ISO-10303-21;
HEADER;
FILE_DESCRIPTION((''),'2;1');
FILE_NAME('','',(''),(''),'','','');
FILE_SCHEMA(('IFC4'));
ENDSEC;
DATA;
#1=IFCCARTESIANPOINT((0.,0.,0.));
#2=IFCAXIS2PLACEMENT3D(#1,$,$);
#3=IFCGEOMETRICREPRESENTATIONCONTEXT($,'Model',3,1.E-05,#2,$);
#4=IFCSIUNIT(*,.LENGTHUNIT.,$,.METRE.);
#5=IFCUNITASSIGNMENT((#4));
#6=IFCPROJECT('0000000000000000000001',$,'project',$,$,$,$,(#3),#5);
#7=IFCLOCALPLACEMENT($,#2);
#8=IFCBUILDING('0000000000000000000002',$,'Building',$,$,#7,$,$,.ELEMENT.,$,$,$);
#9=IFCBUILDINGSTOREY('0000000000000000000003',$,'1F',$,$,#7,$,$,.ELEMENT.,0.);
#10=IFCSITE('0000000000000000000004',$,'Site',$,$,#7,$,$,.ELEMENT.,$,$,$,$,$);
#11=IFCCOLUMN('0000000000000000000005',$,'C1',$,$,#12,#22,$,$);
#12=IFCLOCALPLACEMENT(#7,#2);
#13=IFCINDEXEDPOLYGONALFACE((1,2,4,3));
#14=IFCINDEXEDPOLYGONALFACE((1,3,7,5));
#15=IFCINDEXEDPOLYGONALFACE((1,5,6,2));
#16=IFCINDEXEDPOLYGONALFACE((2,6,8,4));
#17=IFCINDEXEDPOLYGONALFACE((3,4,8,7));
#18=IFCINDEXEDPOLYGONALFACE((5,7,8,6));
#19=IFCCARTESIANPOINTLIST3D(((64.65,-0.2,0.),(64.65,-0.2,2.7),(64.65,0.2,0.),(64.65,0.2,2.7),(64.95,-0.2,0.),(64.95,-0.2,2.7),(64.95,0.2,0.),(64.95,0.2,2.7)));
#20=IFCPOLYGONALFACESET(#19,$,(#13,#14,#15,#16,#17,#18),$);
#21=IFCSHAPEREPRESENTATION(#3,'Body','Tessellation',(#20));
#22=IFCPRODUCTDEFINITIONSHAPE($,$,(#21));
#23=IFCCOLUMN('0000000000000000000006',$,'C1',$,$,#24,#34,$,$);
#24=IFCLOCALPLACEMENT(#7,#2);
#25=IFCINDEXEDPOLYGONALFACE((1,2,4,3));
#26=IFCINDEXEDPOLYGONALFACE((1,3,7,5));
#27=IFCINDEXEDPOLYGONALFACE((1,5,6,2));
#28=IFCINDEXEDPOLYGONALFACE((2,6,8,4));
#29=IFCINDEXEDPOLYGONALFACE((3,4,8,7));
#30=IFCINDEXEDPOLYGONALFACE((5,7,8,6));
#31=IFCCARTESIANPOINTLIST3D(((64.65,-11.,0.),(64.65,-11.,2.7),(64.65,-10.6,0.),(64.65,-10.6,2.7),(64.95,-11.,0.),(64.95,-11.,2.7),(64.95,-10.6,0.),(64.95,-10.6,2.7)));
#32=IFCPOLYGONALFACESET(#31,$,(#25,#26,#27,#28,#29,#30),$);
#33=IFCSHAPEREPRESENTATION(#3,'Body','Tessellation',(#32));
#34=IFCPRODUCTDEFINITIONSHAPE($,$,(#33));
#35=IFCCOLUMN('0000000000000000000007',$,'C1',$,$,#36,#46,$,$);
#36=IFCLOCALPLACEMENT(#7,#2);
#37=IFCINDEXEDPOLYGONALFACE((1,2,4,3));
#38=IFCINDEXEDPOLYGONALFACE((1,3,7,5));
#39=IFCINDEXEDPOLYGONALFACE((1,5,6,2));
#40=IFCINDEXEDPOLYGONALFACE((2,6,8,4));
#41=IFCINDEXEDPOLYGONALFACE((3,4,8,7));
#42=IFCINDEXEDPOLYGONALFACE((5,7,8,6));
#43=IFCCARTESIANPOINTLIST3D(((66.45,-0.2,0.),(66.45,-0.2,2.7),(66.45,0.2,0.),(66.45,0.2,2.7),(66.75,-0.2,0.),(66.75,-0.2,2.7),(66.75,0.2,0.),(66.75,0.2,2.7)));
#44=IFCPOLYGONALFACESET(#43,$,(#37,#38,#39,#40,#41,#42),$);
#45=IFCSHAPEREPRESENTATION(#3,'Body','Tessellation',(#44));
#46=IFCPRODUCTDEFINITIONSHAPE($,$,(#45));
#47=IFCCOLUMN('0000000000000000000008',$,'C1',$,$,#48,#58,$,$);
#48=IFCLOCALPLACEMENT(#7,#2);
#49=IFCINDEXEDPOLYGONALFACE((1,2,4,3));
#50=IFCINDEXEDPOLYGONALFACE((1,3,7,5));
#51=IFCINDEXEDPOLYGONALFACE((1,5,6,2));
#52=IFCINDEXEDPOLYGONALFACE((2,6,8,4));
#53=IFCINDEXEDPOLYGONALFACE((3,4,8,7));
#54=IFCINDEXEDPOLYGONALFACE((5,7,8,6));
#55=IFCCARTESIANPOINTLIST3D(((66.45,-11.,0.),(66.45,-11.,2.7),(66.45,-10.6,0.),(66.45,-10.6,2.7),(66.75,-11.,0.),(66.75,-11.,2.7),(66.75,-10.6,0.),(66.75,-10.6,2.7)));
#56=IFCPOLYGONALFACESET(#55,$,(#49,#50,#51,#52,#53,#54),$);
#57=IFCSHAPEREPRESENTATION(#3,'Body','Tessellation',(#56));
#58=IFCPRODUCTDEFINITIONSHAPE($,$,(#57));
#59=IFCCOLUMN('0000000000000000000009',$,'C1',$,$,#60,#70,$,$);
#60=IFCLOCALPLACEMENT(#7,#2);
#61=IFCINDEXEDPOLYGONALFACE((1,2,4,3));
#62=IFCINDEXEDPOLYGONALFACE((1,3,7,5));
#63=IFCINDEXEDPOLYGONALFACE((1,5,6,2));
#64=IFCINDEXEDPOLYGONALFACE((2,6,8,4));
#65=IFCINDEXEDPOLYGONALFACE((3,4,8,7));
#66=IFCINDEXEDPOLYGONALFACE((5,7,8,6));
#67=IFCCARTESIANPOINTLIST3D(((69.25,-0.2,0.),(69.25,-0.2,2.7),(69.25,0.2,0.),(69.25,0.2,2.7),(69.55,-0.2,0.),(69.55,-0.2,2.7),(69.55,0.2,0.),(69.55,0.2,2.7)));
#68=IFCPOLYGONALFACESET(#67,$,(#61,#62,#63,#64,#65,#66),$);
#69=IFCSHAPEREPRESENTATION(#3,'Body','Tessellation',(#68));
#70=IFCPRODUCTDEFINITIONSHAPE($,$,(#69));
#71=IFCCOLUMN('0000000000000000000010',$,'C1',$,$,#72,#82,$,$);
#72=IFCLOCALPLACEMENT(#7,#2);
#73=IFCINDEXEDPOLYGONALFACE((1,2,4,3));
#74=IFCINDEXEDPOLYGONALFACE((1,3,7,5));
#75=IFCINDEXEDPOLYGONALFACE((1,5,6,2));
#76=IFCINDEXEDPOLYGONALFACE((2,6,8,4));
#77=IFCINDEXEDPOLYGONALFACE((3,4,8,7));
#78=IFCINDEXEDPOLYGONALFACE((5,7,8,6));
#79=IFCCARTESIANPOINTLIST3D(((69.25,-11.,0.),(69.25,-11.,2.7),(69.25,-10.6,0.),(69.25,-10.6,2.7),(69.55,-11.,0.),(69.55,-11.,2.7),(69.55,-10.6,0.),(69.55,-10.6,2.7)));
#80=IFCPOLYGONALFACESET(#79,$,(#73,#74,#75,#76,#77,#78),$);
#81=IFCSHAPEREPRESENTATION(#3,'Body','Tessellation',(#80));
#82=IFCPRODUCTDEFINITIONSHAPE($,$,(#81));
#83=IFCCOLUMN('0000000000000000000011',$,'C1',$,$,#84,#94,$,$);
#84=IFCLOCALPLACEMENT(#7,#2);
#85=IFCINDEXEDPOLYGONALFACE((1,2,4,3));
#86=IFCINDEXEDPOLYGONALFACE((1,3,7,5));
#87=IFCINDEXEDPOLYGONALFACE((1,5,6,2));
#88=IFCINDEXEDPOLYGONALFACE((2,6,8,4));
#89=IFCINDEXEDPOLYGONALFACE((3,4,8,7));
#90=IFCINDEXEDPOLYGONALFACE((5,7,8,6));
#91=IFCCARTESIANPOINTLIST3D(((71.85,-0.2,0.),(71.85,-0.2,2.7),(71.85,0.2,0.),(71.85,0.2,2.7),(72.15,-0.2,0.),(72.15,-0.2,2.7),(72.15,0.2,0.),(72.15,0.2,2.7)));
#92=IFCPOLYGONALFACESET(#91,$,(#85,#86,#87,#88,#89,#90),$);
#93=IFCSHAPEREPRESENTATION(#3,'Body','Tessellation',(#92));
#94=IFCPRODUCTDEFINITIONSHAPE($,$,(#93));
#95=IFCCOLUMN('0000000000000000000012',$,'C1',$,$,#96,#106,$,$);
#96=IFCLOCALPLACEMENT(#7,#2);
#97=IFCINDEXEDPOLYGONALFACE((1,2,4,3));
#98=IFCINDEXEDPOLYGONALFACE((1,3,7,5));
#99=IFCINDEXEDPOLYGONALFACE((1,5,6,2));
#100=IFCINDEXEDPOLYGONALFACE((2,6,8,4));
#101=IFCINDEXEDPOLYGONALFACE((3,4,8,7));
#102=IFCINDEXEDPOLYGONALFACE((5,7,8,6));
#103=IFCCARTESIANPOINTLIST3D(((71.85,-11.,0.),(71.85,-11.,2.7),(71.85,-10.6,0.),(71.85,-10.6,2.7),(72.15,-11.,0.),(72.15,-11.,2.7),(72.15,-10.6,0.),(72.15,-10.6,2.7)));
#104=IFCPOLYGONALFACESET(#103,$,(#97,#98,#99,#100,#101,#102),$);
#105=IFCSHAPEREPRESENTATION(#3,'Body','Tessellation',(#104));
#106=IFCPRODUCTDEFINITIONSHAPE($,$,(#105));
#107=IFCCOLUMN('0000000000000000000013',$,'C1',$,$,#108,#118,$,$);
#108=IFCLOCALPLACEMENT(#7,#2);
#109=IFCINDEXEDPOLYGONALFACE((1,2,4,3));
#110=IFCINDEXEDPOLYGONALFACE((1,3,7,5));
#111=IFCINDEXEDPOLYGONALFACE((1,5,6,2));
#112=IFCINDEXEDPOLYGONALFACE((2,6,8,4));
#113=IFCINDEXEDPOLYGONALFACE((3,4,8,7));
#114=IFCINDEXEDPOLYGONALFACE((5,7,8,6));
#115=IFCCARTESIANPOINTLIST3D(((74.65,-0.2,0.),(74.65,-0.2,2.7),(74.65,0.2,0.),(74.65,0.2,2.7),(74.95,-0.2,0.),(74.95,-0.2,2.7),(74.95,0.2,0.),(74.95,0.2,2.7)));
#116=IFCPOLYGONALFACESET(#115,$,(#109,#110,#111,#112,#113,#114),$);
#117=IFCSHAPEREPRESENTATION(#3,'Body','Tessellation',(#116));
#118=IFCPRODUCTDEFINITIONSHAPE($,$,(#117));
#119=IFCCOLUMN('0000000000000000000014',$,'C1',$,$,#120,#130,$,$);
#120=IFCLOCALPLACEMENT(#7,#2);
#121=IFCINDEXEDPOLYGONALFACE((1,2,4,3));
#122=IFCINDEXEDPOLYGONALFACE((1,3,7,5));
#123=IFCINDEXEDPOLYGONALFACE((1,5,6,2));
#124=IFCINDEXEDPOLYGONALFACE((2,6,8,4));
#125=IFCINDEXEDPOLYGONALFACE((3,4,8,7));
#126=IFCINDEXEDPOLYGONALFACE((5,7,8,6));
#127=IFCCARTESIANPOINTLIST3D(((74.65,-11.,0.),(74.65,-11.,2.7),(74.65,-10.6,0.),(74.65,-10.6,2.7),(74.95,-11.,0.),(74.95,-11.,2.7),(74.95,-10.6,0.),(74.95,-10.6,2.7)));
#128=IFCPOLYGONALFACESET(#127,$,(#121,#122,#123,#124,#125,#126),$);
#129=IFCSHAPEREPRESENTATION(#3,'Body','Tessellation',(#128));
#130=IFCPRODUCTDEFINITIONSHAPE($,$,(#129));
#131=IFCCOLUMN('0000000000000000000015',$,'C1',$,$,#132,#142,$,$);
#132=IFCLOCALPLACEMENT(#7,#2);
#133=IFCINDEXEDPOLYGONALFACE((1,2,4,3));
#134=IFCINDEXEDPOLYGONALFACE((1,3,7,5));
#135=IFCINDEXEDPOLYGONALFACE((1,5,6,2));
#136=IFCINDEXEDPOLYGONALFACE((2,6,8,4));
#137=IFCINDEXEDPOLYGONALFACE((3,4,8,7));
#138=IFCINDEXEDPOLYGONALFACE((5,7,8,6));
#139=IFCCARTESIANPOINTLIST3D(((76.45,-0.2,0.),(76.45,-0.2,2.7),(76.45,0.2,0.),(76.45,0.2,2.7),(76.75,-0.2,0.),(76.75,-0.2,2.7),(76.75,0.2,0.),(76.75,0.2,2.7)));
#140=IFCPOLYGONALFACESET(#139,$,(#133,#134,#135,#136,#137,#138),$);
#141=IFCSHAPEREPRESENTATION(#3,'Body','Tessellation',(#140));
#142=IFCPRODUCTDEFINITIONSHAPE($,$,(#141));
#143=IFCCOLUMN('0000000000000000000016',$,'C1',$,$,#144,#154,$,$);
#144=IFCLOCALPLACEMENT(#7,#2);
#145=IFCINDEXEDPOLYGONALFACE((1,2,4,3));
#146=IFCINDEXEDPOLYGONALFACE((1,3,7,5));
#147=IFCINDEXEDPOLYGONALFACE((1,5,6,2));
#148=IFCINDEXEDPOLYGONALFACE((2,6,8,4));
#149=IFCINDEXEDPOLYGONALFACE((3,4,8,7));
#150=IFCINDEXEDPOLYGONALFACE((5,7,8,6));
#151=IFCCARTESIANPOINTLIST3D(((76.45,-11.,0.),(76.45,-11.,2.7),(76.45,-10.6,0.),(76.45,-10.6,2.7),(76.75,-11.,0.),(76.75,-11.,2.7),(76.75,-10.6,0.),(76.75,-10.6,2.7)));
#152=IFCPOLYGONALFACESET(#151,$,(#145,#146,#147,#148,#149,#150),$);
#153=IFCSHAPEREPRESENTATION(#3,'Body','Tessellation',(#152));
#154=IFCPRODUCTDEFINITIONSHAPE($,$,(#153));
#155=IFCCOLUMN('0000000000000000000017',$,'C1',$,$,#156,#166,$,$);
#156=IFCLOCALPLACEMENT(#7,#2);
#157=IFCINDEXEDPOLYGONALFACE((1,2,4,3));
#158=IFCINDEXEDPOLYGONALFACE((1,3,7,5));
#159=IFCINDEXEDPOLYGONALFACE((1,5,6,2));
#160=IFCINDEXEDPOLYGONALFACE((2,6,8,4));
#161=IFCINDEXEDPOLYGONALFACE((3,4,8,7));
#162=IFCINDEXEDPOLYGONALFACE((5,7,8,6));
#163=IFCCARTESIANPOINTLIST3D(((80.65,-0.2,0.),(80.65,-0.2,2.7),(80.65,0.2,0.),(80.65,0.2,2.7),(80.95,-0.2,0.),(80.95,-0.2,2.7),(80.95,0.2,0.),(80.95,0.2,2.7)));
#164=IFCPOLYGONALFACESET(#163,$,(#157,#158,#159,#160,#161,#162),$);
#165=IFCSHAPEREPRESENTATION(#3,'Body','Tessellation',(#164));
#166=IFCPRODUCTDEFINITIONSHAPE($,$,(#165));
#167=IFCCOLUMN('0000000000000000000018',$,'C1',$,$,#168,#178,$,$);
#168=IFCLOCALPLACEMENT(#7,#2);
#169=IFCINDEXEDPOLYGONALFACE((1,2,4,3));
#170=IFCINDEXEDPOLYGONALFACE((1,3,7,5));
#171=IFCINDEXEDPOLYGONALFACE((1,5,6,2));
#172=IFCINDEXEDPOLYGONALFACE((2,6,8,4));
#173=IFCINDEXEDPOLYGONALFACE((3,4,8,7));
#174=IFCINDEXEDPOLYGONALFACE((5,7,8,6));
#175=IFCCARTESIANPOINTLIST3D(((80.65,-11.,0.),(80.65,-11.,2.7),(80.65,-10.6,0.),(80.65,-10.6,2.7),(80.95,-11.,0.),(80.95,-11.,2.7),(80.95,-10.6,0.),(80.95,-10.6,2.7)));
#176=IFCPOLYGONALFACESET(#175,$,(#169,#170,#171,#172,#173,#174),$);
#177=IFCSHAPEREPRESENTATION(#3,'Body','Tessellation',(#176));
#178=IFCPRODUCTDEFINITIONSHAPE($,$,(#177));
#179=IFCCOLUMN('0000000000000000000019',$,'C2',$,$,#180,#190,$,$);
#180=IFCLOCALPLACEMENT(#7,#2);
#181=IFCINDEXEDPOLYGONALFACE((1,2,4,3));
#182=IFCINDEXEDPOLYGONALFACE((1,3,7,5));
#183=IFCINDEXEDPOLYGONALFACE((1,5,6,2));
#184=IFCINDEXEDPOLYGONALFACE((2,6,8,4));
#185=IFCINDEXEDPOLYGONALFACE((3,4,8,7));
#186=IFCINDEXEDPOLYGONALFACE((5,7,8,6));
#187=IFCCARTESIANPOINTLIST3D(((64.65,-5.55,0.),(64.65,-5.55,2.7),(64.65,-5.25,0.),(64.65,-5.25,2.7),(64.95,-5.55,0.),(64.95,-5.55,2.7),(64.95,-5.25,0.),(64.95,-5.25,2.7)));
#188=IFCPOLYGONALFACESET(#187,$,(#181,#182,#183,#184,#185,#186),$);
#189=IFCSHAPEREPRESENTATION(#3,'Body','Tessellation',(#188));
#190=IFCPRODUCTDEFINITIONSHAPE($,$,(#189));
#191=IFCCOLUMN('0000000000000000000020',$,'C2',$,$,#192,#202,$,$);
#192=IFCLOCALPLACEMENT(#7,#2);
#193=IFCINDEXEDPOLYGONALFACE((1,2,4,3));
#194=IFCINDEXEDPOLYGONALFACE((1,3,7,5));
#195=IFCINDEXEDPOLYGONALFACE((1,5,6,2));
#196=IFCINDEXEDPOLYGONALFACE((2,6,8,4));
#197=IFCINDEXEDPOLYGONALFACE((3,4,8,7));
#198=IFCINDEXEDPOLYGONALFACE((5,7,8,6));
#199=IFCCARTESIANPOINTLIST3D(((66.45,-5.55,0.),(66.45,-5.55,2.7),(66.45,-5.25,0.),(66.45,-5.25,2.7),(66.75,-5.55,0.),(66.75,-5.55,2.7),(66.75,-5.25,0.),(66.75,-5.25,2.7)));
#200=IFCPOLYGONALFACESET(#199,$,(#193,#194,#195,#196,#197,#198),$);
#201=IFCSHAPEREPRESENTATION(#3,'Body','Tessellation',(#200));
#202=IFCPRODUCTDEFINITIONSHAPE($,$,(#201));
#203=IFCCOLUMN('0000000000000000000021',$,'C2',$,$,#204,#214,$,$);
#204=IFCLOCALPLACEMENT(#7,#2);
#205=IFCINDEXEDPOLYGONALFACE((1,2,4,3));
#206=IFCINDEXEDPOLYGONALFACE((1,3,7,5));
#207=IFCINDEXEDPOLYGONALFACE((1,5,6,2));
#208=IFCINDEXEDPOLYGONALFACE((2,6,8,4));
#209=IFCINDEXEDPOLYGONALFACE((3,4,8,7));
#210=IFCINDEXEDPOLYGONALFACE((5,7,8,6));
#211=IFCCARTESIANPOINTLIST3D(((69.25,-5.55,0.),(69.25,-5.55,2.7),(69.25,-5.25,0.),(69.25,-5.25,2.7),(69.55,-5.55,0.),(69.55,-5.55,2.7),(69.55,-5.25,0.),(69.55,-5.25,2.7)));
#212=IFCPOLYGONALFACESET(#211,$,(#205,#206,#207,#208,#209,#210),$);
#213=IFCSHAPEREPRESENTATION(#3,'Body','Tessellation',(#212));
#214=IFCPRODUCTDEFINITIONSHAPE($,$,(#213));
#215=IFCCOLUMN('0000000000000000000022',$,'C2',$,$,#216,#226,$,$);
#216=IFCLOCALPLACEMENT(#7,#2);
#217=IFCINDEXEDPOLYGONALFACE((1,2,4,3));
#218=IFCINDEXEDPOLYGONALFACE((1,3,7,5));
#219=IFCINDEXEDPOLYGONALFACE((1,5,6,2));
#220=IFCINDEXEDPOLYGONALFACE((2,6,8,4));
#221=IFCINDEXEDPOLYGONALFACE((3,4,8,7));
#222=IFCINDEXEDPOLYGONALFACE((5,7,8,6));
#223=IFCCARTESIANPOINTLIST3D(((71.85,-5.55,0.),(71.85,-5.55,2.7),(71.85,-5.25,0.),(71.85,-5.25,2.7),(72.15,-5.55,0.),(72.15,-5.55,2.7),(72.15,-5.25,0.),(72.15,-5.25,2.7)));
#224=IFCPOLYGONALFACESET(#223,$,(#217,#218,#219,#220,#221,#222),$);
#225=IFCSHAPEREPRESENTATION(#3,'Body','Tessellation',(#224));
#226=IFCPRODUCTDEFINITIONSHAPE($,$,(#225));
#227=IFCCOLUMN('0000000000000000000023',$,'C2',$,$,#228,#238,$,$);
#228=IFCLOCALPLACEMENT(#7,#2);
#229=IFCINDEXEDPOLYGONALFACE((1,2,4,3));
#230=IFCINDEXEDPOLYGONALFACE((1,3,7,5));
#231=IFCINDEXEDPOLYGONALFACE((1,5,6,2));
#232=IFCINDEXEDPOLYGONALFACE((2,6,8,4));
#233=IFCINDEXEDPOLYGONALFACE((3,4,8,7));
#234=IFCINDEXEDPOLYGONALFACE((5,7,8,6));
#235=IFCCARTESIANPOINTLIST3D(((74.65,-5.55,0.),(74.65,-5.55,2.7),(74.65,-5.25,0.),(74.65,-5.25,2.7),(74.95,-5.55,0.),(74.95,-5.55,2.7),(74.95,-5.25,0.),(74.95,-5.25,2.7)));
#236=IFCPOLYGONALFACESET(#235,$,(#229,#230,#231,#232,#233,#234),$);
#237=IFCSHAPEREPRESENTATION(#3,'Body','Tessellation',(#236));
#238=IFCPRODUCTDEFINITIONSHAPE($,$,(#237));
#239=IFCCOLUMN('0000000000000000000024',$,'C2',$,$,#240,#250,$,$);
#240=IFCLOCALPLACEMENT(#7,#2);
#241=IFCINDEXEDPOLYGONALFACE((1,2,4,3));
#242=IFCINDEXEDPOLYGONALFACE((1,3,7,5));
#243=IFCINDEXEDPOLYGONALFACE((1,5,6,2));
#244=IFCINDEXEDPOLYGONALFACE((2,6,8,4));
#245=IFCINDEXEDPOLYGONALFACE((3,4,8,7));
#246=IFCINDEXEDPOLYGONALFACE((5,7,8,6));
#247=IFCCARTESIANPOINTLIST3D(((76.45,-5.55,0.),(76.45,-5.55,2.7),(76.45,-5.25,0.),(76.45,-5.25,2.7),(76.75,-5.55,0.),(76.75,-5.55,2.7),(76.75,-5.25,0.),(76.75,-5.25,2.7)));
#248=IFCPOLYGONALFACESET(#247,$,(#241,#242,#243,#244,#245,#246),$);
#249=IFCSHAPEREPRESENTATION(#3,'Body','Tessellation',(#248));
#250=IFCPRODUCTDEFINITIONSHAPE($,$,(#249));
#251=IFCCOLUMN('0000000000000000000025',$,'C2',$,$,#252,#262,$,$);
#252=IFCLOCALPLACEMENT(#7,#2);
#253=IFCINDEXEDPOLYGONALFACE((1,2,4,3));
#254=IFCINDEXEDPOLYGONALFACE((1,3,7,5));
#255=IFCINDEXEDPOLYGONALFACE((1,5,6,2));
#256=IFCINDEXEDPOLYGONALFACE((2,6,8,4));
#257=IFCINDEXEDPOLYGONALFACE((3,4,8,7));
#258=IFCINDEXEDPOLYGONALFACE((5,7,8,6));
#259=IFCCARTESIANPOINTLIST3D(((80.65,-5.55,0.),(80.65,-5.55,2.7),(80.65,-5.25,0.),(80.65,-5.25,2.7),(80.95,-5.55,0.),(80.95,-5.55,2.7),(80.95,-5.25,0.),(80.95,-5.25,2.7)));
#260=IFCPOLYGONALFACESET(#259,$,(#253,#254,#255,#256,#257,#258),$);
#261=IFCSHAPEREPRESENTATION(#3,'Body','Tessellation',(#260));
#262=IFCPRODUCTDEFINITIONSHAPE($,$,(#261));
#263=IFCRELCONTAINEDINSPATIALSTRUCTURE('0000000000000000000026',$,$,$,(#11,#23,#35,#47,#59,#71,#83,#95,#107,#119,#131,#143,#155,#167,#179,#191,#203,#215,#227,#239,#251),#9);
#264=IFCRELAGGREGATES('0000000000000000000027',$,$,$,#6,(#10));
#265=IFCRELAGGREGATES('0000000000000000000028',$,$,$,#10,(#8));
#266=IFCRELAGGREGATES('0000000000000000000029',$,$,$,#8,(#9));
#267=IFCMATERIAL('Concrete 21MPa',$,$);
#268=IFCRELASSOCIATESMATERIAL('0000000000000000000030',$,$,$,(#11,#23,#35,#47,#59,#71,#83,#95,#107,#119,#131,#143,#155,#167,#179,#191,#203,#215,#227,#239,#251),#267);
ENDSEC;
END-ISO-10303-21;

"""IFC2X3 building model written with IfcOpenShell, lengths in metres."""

from ifc_helpers import new_model, si_unit, frame, origin, origin_2d, place, context, project, spatial, rectangle, extrude, material, element, save


model = new_model("IFC2X3")

# Units and contexts
model_context = context("Model", 3, precision=1e-05, world=origin())
ifc_project = project(units=[si_unit("LENGTHUNIT", "METRE")], contexts=[model_context])

# Site, building, storey
placement = place(None, origin())
site = spatial("IfcSite", under=ifc_project, at=placement, Name="Site", CompositionType="ELEMENT")
building = spatial("IfcBuilding", under=site, at=placement, Name="Building", CompositionType="ELEMENT")
storey = spatial("IfcBuildingStorey", under=building, at=placement, Name="1F", CompositionType="ELEMENT", Elevation=0.0)

# Columns
ifc_material = material(Name="Concrete 21MPa")
for number, where, name in (
    (1, (64.8, 0.0, 0.0), "C1"),
    (2, (64.8, -10.8, 0.0), "C1"),
    (3, (66.6, 0.0, 0.0), "C1"),
    (4, (66.6, -10.8, 0.0), "C1"),
    (5, (69.4, 0.0, 0.0), "C1"),
    (6, (69.4, -10.8, 0.0), "C1"),
    (7, (72.0, 0.0, 0.0), "C1"),
    (8, (72.0, -10.8, 0.0), "C1"),
    (9, (74.8, 0.0, 0.0), "C1"),
    (10, (74.8, -10.8, 0.0), "C1"),
    (11, (76.6, 0.0, 0.0), "C1"),
    (12, (76.6, -10.8, 0.0), "C1"),
    (13, (80.8, 0.0, 0.0), "C1"),
    (14, (80.8, -10.8, 0.0), "C1"),
):
    element("IfcColumn", number, at=place(None, frame(where)), inside=storey, material=ifc_material, Name=name, context=model_context, shape_type="SweptSolid", body=[
        extrude(rectangle(XDim=0.3, YDim=0.4, at=origin_2d()), origin(), (0.0, 0.0, 1.0), 2.7),
    ])
for number, where, name in (
    (15, (64.8, -5.4, 0.0), "C2"),
    (16, (66.6, -5.4, 0.0), "C2"),
    (17, (69.4, -5.4, 0.0), "C2"),
    (18, (72.0, -5.4, 0.0), "C2"),
    (19, (74.8, -5.4, 0.0), "C2"),
    (20, (76.6, -5.4, 0.0), "C2"),
    (21, (80.8, -5.4, 0.0), "C2"),
):
    element("IfcColumn", number, at=place(None, frame(where)), inside=storey, material=ifc_material, Name=name, context=model_context, shape_type="SweptSolid", body=[
        extrude(rectangle(XDim=0.3, YDim=0.3, at=origin_2d()), origin(), (0.0, 0.0, 1.0), 2.7),
    ])

save(model, "model.ifc")
